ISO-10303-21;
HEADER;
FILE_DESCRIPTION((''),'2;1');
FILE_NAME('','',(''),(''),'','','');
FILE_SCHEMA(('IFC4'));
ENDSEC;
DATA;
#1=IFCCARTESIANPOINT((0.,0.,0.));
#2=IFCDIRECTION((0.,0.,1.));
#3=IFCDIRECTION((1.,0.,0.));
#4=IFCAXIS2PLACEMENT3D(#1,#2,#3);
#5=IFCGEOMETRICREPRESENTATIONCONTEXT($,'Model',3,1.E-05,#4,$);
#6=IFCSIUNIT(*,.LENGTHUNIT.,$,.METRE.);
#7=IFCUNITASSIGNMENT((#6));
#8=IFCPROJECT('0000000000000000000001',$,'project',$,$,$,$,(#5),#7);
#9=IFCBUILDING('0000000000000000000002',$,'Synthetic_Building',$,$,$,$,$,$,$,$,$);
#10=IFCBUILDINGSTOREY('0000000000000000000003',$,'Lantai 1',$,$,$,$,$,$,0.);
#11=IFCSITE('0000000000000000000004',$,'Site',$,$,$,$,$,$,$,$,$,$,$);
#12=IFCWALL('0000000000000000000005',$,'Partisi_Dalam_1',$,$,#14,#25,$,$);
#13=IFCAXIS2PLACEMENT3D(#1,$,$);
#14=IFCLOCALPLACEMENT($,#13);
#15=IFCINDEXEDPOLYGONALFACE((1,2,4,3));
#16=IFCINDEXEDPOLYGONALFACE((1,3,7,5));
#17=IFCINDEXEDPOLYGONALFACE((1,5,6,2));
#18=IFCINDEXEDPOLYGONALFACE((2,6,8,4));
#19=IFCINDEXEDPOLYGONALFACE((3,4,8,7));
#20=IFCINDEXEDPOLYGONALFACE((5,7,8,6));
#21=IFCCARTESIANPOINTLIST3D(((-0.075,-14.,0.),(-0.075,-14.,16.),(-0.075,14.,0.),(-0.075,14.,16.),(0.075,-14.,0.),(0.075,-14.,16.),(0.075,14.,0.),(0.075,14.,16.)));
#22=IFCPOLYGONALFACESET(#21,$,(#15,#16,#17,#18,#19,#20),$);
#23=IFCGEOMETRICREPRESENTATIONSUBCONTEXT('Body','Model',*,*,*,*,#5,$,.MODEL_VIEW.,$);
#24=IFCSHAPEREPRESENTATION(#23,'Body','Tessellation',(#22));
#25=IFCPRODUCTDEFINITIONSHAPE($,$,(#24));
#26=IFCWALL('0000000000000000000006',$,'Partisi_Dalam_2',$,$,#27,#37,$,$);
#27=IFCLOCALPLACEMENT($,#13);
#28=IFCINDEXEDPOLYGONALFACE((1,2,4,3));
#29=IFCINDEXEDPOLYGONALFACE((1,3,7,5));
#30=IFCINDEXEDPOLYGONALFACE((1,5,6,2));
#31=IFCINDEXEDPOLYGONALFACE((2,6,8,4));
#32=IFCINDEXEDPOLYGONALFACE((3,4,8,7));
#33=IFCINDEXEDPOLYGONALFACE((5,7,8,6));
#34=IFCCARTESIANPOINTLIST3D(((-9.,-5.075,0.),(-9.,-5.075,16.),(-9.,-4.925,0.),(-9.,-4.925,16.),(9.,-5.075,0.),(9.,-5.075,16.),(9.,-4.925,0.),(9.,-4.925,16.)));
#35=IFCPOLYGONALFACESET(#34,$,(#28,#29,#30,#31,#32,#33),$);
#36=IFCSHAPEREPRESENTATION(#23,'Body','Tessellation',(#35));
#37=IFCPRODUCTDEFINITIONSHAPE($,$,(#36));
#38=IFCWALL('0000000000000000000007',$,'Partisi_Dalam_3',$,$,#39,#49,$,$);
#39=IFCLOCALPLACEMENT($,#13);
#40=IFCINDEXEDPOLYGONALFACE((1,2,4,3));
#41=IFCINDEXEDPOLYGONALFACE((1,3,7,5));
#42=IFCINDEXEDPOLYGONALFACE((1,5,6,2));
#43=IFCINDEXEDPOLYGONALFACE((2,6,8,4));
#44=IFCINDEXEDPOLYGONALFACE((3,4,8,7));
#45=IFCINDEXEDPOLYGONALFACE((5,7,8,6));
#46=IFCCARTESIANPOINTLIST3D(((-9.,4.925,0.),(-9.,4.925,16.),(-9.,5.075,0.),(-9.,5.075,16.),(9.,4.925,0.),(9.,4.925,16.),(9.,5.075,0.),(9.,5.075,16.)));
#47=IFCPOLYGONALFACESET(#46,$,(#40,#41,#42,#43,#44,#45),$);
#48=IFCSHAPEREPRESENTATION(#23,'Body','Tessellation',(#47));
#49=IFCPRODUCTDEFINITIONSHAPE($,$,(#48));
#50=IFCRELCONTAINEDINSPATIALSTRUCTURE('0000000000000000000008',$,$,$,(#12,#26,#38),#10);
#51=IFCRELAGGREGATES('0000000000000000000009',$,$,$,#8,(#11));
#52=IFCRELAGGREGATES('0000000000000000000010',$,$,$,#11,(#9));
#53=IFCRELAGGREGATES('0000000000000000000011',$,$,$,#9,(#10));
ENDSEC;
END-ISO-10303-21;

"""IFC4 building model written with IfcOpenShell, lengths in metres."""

from ifc_helpers import new_model, si_unit, origin_with_axes, place, context, subcontext, project, spatial, polyline, outline, extrude, element, save


model = new_model("IFC4")

# Units and contexts
model_context = context("Model", 3, precision=1e-05, world=origin_with_axes())
body_context = subcontext(model_context, "Body", "Model", "MODEL_VIEW")
ifc_project = project(units=[si_unit("LENGTHUNIT", "METRE")], contexts=[model_context])

# Site, building, storey
site = spatial("IfcSite", under=ifc_project, Name="Site")
building = spatial("IfcBuilding", under=site, Name="Synthetic_Building")
storey = spatial("IfcBuildingStorey", under=building, Name="Lantai 1", Elevation=0.0)

# Walls
wall_1_placement = place(None, origin_with_axes())
element("IfcWall", 1, at=wall_1_placement, inside=storey, Name="Partisi_Dalam_1", context=body_context, shape_type="SweptSolid", body=[
    extrude(outline(polyline([(0.075, -14.0), (0.075, 14.0), (-0.075, 14.0), (-0.075, -14.0), (0.075, -14.0)])), origin_with_axes(), (0.0, 0.0, 1.0), 16.0),
])
wall_2_placement = place(None, origin_with_axes())
element("IfcWall", 2, at=wall_2_placement, inside=storey, Name="Partisi_Dalam_2", context=body_context, shape_type="SweptSolid", body=[
    extrude(outline(polyline([(-9.0, -5.075), (9.0, -5.075), (9.0, -4.925), (-9.0, -4.925), (-9.0, -5.075)])), origin_with_axes(), (0.0, 0.0, 1.0), 16.0),
])
wall_3_placement = place(None, origin_with_axes())
element("IfcWall", 3, at=wall_3_placement, inside=storey, Name="Partisi_Dalam_3", context=body_context, shape_type="SweptSolid", body=[
    extrude(outline(polyline([(-9.0, 4.925), (9.0, 4.925), (9.0, 5.075), (-9.0, 5.075), (-9.0, 4.925)])), origin_with_axes(), (0.0, 0.0, 1.0), 16.0),
])

save(model, "model.ifc")
